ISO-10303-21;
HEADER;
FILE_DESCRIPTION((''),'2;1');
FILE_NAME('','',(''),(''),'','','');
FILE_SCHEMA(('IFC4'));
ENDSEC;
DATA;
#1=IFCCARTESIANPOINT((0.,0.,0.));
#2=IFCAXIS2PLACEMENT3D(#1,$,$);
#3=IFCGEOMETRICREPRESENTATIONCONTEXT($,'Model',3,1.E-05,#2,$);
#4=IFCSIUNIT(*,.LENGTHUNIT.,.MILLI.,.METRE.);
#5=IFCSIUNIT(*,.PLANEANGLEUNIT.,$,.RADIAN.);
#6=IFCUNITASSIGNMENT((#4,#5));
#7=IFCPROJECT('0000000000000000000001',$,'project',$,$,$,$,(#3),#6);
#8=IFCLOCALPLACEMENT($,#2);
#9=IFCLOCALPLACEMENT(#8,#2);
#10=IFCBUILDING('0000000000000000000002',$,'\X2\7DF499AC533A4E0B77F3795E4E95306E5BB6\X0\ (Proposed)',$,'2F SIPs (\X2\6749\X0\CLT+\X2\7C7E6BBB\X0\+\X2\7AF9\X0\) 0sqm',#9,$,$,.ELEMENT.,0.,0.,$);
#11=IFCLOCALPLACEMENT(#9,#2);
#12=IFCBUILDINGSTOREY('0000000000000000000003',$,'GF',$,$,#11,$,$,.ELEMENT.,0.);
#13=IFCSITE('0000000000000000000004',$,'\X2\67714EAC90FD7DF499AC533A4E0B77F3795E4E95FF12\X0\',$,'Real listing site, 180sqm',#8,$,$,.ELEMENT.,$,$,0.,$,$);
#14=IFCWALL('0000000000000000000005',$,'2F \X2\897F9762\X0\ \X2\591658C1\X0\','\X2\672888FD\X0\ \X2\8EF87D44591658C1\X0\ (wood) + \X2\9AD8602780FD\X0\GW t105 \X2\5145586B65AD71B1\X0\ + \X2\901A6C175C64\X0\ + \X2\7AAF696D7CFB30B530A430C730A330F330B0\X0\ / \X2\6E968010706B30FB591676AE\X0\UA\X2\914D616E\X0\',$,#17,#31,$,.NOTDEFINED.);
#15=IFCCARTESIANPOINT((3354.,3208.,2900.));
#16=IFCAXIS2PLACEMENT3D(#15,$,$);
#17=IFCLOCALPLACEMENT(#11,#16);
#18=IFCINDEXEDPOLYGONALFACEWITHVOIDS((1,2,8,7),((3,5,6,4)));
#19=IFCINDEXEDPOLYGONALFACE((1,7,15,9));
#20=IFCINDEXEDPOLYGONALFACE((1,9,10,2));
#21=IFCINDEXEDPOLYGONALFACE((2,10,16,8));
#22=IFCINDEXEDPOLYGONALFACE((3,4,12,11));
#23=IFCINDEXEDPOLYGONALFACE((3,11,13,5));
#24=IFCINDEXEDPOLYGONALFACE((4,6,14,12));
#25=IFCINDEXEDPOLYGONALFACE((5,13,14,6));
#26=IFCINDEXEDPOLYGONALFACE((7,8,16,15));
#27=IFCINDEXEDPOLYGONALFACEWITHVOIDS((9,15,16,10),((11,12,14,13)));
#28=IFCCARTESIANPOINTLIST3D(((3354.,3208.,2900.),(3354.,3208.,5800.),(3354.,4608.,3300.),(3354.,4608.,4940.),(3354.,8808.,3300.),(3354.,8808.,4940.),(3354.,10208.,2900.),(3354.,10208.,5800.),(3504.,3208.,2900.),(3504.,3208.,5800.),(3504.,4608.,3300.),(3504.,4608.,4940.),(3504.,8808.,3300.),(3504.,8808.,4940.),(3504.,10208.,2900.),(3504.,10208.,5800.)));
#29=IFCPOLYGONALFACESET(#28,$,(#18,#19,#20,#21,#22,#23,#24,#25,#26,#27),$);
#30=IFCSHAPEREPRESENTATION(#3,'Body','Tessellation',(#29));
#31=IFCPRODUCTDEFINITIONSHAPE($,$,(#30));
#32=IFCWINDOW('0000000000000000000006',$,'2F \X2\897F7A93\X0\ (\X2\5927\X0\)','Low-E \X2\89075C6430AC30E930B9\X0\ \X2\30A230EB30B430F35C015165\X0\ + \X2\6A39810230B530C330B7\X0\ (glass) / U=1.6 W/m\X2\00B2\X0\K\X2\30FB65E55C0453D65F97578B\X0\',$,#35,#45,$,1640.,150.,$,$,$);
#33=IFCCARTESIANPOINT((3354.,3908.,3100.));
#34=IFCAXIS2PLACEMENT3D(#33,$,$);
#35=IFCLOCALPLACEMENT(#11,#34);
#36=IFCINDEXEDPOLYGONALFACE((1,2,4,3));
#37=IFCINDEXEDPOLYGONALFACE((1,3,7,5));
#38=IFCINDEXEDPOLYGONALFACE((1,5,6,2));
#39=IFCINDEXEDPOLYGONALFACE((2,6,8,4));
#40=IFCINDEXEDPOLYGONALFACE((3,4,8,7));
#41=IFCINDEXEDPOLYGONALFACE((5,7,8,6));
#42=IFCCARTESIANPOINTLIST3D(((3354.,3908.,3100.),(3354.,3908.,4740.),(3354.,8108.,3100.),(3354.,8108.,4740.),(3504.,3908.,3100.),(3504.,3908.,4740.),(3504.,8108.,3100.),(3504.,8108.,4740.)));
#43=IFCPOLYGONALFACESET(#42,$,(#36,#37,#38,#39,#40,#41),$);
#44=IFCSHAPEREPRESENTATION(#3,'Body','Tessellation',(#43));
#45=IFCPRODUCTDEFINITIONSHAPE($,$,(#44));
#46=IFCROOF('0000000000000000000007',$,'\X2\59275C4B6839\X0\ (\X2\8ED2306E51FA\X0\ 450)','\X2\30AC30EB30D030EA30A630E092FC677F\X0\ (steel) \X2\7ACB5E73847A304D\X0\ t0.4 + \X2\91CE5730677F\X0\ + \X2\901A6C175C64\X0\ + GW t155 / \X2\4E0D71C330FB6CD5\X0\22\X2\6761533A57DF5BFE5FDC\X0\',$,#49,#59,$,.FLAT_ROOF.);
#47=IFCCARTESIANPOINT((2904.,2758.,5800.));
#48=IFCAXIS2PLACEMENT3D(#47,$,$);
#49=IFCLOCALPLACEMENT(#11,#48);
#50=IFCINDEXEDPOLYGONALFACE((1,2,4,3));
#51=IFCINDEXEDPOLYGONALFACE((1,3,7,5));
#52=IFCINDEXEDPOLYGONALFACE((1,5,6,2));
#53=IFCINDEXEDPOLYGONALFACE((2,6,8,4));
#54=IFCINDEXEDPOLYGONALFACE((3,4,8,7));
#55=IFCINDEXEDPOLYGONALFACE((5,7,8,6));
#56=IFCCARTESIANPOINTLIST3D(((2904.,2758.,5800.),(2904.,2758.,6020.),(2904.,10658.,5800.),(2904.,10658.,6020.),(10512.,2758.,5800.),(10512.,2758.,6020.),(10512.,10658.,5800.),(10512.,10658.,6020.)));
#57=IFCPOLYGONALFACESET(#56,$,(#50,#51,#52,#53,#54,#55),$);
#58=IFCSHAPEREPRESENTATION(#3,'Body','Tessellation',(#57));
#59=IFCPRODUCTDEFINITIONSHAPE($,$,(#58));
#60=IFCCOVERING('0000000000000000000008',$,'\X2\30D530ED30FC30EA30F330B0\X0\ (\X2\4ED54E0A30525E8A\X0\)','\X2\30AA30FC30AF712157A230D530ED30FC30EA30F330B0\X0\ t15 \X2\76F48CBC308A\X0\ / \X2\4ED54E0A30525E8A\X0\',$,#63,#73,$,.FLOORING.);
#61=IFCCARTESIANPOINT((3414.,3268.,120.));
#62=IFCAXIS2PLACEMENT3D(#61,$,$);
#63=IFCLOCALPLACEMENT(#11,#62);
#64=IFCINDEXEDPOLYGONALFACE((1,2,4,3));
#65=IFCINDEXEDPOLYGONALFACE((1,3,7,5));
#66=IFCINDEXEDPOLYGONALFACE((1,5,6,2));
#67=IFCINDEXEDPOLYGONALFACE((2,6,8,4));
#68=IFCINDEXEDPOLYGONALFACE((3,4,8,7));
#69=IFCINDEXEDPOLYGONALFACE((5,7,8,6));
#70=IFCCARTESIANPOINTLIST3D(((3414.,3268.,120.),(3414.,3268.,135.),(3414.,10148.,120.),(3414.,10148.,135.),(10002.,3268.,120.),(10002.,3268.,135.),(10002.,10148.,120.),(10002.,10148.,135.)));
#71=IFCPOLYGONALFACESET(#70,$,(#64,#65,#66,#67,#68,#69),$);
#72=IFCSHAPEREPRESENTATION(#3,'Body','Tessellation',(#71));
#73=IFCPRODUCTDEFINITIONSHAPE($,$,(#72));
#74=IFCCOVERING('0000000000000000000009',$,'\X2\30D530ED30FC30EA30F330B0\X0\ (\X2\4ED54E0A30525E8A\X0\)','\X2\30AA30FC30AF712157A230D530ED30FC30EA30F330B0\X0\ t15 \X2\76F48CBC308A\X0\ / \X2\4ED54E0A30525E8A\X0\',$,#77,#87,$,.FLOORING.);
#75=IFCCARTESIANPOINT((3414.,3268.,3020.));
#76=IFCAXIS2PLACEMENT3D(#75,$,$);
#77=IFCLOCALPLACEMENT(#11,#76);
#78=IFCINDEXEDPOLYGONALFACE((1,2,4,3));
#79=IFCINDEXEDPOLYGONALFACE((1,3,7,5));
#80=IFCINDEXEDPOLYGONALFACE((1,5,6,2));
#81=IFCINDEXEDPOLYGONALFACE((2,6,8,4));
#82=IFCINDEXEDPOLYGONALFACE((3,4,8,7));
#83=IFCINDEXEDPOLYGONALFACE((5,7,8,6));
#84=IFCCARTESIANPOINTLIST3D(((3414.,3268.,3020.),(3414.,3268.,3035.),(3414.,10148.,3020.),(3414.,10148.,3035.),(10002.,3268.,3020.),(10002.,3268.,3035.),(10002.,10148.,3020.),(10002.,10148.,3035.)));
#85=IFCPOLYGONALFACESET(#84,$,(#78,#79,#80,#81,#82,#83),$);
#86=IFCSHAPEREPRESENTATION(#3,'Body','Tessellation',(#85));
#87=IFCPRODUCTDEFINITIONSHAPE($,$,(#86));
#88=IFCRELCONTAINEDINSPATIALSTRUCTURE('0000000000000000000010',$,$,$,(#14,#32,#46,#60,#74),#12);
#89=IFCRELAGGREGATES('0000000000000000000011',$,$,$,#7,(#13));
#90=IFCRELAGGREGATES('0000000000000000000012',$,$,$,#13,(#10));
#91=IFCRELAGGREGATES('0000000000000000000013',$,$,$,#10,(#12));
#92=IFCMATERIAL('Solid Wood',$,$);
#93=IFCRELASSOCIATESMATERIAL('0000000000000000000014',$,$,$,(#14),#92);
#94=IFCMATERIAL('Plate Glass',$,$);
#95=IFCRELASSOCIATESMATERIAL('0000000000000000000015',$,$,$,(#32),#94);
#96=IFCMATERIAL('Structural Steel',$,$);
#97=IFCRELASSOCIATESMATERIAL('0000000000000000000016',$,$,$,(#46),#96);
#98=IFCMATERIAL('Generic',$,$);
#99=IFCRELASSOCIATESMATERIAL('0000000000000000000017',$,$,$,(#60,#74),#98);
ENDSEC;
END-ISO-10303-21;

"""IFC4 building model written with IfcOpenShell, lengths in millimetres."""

from ifc_helpers import new_model, si_unit, frame, frame_2d, origin, place, context, project, spatial, rectangle, extrude, material, element, fill, save


model = new_model("IFC4")

# Units and contexts
model_context = context("Model", 3, precision=1e-05, world=origin())
ifc_project = project(units=[si_unit("LENGTHUNIT", "METRE", prefix="MILLI"), si_unit("PLANEANGLEUNIT", "RADIAN")], contexts=[model_context])

# Site, building, storey
site_placement = place(None, origin())
site = spatial("IfcSite", under=ifc_project, at=site_placement, Name="東京都練馬区下石神井２", ObjectType="Real listing site, 180sqm", CompositionType="ELEMENT", RefElevation=0.0)
building_placement = place(site_placement, origin())
building = spatial("IfcBuilding", under=site, at=building_placement, Name="練馬区下石神井の家 (Proposed)", ObjectType="2F SIPs (杉CLT+籾殻+竹) 0sqm", CompositionType="ELEMENT", ElevationOfRefHeight=0.0, ElevationOfTerrain=0.0)
storey_placement = place(building_placement, origin())
storey = spatial("IfcBuildingStorey", under=building, at=storey_placement, Name="GF", CompositionType="ELEMENT", Elevation=0.0)

# Shared definitions
ifc_material_1 = material(Name="Solid Wood")

# Shared definitions
ifc_material_2 = material(Name="Plate Glass")

# Wall, opening, window
wall_1_placement = place(storey_placement, frame((3354.0, 3208.0, 2900.0)))
wall_1 = element("IfcWall", 1, at=wall_1_placement, inside=storey, material=ifc_material_1, Name="2F 西面 外壁", Description="木製 軸組外壁 (wood) + 高性能GW t105 充填断熱 + 通気層 + 窯業系サイディング / 準耐火・外皮UA配慮", PredefinedType="NOTDEFINED", context=model_context, shape_type="SweptSolid", body=[
    extrude(rectangle(XDim=150.0, YDim=7000.0, at=frame_2d((75.0, 3500.0))), frame((3354.0, 3208.0, 2900.0)), (0.0, 0.0, 1.0), 2900.0),
])
opening_1_placement = place(storey_placement, frame((3354.0, 3908.0, 3100.0)))
opening_1 = element("IfcOpeningElement", 2, at=opening_1_placement, cuts=wall_1, PredefinedType="NOTDEFINED", context=model_context, shape_type="SweptSolid", body=[
    extrude(rectangle(XDim=150.0, YDim=4200.0, at=frame_2d((75.0, 2100.0))), frame((3354.0, 3908.0, 3100.0)), (0.0, 0.0, 1.0), 1640.0),
])
window_1_placement = place(storey_placement, frame((3354.0, 3908.0, 3100.0)))
window_1 = element("IfcWindow", 3, at=window_1_placement, inside=storey, material=ifc_material_2, Name="2F 西窓 (大)", Description="Low-E 複層ガラス アルゴン封入 + 樹脂サッシ (glass) / U=1.6 W/m²K・日射取得型", OverallHeight=1640.0, OverallWidth=150.0, context=model_context, shape_type="SweptSolid", body=[
    extrude(rectangle(XDim=150.0, YDim=4200.0, at=frame_2d((75.0, 2100.0))), frame((3354.0, 3908.0, 3100.0)), (0.0, 0.0, 1.0), 1640.0),
])
fill(opening_1, window_1)

# Roof
ifc_material_3 = material(Name="Structural Steel")
roof_placement = place(storey_placement, frame((2904.0, 2758.0, 5800.0)))
element("IfcRoof", 4, at=roof_placement, inside=storey, material=ifc_material_3, Name="大屋根 (軒の出 450)", Description="ガルバリウム鋼板 (steel) 立平葺き t0.4 + 野地板 + 通気層 + GW t155 / 不燃・法22条区域対応", PredefinedType="FLAT_ROOF", context=model_context, shape_type="SweptSolid", body=[
    extrude(rectangle(XDim=7608.0, YDim=7900.0, at=frame_2d((3804.0, 3950.0))), frame((2904.0, 2758.0, 5800.0)), (0.0, 0.0, 1.0), 220.0),
])

# Coverings
ifc_material_4 = material(Name="Generic")
covering_1_placement = place(storey_placement, frame((3414.0, 3268.0, 120.0)))
element("IfcCovering", 5, at=covering_1_placement, inside=storey, material=ifc_material_4, Name="フローリング (仕上げ床)", Description="オーク無垢フローリング t15 直貼り / 仕上げ床", PredefinedType="FLOORING", context=model_context, shape_type="SweptSolid", body=[
    extrude(rectangle(XDim=6588.0, YDim=6880.0, at=frame_2d((3294.0, 3440.0))), frame((3414.0, 3268.0, 120.0)), (0.0, 0.0, 1.0), 15.0),
])
covering_2_placement = place(storey_placement, frame((3414.0, 3268.0, 3020.0)))
element("IfcCovering", 6, at=covering_2_placement, inside=storey, material=ifc_material_4, Name="フローリング (仕上げ床)", Description="オーク無垢フローリング t15 直貼り / 仕上げ床", PredefinedType="FLOORING", context=model_context, shape_type="SweptSolid", body=[
    extrude(rectangle(XDim=6588.0, YDim=6880.0, at=frame_2d((3294.0, 3440.0))), frame((3414.0, 3268.0, 3020.0)), (0.0, 0.0, 1.0), 15.0),
])

save(model, "model.ifc")
